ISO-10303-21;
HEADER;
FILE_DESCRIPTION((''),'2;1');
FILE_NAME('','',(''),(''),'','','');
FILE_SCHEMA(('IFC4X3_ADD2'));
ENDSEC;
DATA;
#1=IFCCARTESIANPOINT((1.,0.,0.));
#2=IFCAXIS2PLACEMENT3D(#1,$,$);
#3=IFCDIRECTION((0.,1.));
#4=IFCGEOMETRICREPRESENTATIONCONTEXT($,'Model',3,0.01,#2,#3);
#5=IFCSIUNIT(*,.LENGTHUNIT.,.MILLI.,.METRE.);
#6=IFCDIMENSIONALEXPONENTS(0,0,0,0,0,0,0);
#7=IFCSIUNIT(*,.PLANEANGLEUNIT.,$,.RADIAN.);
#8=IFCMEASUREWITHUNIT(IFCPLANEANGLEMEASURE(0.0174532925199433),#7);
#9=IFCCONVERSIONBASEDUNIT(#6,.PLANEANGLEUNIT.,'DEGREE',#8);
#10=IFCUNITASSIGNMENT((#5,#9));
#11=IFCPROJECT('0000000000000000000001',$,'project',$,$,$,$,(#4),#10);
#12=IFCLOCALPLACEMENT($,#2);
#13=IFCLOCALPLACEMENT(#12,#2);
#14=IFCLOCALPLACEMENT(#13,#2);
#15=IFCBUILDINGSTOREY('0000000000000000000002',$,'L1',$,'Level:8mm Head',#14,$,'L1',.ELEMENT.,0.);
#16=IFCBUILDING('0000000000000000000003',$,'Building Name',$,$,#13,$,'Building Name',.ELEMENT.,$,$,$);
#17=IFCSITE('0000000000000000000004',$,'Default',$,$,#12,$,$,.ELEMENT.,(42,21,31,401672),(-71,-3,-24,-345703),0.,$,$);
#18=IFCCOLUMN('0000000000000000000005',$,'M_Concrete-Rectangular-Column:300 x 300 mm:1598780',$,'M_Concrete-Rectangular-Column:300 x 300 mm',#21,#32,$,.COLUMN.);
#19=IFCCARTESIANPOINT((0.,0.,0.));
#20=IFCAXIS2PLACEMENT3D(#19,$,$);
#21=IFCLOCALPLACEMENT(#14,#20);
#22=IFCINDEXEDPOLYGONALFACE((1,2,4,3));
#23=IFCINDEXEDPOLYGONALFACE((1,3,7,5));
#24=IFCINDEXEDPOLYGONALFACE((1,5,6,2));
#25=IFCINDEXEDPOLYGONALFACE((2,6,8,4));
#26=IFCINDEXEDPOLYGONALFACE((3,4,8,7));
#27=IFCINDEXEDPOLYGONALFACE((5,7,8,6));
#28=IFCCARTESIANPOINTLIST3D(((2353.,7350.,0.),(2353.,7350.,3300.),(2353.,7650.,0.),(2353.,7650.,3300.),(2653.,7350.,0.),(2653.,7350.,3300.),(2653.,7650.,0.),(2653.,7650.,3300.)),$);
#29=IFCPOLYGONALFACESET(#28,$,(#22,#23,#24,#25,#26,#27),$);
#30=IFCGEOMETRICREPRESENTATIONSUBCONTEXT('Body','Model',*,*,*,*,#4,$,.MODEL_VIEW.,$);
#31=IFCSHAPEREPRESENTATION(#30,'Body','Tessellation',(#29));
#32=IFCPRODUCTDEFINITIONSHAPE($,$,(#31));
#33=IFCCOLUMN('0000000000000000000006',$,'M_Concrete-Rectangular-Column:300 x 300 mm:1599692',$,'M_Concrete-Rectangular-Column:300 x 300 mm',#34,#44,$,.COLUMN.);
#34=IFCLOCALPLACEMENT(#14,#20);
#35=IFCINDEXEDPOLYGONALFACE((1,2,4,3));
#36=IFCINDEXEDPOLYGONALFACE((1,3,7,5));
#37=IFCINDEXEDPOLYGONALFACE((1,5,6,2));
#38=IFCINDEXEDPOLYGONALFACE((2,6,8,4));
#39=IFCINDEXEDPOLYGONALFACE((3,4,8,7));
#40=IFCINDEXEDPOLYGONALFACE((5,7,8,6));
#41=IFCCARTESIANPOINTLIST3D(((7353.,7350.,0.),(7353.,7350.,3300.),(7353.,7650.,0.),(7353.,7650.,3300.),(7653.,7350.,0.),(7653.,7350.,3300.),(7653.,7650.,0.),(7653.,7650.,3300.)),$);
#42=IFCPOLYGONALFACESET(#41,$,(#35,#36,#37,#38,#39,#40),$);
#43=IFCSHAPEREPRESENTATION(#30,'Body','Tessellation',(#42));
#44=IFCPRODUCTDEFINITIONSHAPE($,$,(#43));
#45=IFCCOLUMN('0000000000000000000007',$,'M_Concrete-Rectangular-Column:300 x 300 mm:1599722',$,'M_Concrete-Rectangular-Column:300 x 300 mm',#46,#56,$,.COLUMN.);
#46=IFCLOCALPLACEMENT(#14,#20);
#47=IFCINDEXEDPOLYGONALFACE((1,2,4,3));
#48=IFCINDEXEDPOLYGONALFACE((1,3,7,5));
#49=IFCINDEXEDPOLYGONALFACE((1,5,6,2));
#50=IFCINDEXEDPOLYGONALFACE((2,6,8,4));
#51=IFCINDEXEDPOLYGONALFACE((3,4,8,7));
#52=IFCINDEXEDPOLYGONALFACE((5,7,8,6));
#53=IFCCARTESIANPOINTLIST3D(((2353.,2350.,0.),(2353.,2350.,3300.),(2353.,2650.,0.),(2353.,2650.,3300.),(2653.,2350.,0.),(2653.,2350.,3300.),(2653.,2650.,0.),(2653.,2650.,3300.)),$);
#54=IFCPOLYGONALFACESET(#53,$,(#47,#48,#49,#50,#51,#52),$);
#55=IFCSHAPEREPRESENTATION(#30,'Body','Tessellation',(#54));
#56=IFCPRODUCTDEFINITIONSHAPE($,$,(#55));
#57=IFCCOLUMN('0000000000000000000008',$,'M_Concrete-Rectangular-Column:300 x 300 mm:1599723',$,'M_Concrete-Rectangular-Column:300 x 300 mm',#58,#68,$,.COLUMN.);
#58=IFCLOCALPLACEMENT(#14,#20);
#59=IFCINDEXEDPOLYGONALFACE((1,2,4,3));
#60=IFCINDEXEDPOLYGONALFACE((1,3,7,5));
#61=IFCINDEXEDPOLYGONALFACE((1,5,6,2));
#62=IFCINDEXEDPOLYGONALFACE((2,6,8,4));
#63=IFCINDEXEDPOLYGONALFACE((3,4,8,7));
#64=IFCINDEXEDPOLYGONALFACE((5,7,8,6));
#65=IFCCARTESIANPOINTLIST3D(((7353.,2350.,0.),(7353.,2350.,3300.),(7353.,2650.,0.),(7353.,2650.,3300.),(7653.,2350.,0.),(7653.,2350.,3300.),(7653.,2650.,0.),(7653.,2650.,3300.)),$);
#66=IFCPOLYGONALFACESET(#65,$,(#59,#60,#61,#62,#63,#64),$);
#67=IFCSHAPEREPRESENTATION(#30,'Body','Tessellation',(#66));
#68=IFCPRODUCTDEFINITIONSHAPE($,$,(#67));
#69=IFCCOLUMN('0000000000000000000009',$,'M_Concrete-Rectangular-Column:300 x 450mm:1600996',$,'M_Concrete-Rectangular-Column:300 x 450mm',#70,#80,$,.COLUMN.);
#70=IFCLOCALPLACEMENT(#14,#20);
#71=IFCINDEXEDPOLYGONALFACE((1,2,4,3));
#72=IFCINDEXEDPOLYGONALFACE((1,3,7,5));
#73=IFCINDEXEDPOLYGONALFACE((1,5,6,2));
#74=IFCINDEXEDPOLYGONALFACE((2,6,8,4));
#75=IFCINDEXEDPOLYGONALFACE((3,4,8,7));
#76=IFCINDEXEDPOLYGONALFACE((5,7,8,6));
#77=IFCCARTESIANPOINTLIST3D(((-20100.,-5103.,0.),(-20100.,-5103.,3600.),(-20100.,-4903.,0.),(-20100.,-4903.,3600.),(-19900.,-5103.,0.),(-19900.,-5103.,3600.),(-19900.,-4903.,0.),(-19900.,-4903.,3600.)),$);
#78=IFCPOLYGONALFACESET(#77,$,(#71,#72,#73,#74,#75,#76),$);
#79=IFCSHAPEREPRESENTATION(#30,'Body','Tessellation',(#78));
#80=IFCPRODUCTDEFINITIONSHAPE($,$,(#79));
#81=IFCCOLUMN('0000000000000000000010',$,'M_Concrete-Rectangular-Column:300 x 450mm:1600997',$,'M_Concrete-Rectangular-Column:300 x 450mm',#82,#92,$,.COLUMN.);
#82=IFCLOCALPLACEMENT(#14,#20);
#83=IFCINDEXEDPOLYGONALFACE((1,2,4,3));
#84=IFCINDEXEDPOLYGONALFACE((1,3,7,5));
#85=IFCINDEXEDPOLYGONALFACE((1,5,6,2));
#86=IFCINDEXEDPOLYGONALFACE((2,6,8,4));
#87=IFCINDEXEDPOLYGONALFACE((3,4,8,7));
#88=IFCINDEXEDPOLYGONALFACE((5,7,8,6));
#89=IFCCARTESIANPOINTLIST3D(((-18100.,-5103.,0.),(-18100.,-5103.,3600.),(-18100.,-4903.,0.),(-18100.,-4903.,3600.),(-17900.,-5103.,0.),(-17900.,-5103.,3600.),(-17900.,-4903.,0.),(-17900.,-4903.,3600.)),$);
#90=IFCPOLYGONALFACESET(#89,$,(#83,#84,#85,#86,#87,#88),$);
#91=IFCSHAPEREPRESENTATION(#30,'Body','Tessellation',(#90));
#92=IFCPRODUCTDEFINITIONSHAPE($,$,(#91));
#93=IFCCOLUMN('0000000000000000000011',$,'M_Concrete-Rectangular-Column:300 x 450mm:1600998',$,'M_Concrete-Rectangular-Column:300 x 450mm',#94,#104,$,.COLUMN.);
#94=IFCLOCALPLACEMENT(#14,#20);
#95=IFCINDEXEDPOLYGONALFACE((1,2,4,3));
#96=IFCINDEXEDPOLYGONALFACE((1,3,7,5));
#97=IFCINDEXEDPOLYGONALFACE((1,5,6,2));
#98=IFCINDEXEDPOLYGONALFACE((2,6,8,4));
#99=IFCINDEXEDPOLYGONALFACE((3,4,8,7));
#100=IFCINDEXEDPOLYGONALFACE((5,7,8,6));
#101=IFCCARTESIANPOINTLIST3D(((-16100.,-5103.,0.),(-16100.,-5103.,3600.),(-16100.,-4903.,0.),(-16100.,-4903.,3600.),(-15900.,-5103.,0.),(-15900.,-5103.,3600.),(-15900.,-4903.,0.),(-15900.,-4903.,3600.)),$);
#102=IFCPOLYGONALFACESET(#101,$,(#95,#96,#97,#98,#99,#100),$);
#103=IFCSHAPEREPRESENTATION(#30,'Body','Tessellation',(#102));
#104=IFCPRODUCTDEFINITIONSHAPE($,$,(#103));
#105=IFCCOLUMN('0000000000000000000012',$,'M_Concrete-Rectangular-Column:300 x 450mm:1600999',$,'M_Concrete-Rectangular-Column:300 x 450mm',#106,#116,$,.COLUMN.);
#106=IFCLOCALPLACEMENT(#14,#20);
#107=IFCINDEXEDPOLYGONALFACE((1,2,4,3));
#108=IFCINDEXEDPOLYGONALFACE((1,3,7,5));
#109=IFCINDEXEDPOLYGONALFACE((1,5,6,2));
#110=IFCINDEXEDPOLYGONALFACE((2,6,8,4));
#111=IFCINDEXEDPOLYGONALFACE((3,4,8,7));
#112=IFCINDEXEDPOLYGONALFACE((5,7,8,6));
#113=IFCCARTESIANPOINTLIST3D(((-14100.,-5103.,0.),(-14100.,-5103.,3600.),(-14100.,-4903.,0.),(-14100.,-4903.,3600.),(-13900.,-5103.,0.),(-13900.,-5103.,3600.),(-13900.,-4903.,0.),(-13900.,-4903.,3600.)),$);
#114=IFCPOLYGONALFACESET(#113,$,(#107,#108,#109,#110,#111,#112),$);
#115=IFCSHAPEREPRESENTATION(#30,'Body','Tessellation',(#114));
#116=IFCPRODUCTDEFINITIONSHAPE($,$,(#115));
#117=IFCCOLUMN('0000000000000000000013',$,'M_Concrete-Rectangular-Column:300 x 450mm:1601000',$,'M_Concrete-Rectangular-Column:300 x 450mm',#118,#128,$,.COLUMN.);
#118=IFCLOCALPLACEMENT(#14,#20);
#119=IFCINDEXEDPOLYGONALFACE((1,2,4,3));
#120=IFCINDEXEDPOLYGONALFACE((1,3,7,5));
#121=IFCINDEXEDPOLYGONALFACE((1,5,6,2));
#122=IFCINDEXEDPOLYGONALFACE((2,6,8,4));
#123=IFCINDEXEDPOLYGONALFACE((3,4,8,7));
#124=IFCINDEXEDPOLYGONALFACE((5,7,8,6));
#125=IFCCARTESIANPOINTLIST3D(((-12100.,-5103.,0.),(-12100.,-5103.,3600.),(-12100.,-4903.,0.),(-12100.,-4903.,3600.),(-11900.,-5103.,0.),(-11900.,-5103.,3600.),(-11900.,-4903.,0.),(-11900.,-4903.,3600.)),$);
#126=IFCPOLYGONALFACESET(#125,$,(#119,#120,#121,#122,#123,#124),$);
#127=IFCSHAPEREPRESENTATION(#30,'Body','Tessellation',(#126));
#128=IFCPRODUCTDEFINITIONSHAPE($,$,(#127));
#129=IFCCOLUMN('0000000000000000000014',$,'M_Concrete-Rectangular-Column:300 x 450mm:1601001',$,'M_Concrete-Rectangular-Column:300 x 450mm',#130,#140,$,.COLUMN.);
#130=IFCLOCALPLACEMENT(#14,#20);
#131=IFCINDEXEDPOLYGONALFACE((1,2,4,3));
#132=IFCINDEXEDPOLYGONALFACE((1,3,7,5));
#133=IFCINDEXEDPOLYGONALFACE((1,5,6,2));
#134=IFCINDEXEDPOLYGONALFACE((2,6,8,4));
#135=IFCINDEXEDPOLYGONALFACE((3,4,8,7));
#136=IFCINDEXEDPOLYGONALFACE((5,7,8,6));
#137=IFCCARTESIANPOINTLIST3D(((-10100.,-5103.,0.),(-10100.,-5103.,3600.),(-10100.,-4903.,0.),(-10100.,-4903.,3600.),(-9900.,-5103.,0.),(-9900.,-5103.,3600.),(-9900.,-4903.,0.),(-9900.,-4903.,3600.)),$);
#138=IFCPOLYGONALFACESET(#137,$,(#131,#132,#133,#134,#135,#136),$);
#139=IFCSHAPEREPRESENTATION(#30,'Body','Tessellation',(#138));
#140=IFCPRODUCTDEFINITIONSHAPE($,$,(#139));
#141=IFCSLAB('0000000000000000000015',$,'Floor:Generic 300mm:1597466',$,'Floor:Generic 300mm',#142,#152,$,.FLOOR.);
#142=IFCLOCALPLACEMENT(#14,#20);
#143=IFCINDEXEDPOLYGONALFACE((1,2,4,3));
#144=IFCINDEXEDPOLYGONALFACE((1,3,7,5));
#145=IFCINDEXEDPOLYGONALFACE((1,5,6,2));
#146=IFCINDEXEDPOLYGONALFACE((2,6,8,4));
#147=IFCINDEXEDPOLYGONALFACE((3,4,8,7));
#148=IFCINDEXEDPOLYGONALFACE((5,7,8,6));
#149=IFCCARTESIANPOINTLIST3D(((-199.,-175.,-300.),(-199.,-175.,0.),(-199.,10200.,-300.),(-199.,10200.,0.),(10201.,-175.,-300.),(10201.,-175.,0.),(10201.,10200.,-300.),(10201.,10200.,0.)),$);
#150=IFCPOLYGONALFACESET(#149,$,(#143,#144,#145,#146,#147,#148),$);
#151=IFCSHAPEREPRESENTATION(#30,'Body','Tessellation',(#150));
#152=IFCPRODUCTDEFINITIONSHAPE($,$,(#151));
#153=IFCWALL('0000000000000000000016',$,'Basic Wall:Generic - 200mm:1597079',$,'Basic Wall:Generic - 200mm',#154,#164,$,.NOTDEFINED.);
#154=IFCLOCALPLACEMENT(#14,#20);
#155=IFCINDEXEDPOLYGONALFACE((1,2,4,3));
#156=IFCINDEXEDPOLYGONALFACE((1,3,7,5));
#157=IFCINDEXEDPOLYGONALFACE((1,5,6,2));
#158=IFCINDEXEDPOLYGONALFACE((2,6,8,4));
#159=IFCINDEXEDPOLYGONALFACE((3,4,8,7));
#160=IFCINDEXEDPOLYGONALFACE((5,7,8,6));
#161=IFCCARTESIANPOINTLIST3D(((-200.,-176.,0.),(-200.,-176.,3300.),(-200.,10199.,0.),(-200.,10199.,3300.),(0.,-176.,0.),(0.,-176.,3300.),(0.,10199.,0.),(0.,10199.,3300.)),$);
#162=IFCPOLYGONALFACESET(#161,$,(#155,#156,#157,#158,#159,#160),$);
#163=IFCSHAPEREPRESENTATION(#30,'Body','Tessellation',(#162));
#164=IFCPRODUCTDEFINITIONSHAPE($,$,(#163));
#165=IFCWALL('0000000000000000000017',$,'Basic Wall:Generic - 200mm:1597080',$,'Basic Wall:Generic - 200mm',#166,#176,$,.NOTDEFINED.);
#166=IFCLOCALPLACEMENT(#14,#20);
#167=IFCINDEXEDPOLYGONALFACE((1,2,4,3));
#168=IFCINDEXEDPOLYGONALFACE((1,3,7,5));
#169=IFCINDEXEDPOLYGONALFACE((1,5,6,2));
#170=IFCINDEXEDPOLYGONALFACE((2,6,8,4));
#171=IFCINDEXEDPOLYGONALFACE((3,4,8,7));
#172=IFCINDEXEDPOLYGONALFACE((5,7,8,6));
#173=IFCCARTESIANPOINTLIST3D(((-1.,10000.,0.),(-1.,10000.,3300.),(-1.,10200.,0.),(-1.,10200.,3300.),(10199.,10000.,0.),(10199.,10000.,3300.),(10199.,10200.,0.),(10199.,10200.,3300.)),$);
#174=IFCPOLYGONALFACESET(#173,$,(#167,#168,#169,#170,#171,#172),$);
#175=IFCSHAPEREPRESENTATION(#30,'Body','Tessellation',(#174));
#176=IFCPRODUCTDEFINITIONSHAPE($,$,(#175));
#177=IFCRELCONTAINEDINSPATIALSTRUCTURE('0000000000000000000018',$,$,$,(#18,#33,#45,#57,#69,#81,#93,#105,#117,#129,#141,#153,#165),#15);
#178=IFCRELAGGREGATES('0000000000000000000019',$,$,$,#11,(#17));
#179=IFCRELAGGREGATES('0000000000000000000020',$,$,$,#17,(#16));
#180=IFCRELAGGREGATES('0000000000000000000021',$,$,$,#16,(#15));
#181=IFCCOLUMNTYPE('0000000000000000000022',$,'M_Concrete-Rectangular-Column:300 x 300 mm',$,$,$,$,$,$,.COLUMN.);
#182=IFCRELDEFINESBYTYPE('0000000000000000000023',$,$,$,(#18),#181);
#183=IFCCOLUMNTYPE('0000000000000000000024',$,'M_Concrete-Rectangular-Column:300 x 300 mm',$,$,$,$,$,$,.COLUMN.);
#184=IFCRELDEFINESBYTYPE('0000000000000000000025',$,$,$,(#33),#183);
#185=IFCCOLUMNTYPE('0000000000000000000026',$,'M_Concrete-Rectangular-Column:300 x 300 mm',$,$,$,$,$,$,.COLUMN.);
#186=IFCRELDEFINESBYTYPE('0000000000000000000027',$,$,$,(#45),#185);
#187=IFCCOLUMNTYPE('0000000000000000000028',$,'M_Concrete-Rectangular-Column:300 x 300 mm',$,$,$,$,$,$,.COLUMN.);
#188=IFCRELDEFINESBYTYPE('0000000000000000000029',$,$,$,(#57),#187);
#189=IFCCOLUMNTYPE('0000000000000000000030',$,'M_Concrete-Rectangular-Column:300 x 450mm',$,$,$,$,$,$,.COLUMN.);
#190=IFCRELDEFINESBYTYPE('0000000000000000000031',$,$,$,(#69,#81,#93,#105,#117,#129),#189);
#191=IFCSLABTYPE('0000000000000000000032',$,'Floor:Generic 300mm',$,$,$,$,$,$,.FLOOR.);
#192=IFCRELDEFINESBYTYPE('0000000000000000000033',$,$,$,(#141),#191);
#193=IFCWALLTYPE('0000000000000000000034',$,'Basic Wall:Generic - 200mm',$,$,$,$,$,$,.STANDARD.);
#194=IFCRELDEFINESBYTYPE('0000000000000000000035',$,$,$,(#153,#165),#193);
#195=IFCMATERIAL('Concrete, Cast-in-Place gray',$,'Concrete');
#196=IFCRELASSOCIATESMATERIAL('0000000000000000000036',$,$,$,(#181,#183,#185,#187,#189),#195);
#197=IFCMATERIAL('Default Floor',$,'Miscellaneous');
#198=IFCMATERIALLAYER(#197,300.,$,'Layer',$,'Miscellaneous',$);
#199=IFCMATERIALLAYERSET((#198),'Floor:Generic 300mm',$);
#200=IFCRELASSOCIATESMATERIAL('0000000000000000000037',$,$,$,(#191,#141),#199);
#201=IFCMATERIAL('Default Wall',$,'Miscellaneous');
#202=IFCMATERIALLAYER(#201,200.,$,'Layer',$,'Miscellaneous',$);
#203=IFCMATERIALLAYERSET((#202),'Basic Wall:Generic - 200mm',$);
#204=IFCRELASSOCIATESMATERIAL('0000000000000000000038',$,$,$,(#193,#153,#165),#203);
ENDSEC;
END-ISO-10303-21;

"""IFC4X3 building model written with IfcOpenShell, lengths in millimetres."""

from ifc_helpers import new_model, entity, si_unit, converted_unit, direction, frame, frame_2d, origin_2d_with_axis, place, context, subcontext, project, spatial, rectangle, extrude, source, transform, mapped, material, layer, layer_set, layer_usage, material_profile, profile_set, type_object, type_shapes, element, save


model = new_model("IFC4X3")

# Units and contexts
model_context = context("Model", 3, precision=0.01, world=frame((1.0, 0.0, 0.0)), true_north=direction((0.0, 1.0)))
body_context = subcontext(model_context, "Body", "Model", "MODEL_VIEW")
ifc_project = project(units=[si_unit("LENGTHUNIT", "METRE", prefix="MILLI"), converted_unit("PLANEANGLEUNIT", "DEGREE", entity("IfcPlaneAngleMeasure", 0.0174532925199433), si_unit("PLANEANGLEUNIT", "RADIAN"), dimensions=[0, 0, 0, 0, 0, 0, 0])], contexts=[model_context])

# Site, building, storey
site_placement = place(None, frame((1.0, 0.0, 0.0)))
site = spatial("IfcSite", under=ifc_project, at=site_placement, Name="Default", CompositionType="ELEMENT", RefLatitude=(42, 21, 31, 401672), RefLongitude=(-71, -3, -24, -345703), RefElevation=0.0)
building_placement = place(site_placement, frame((1.0, 0.0, 0.0)))
building = spatial("IfcBuilding", under=site, at=building_placement, Name="Building Name", LongName="Building Name", CompositionType="ELEMENT")
storey_placement = place(building_placement, frame((1.0, 0.0, 0.0)))
storey = spatial("IfcBuildingStorey", under=building, at=storey_placement, Name="L1", ObjectType="Level:8mm Head", LongName="L1", CompositionType="ELEMENT", Elevation=0.0)

# Columns
ifc_material_1 = material(Name="Concrete, Cast-in-Place gray", Category="Concrete")
ifc_material_profile_1 = material_profile(ifc_material_1, rectangle(XDim=300.0, YDim=300.0, at=origin_2d_with_axis()), Name="300 x 300 mm")
ifc_profile_set_1 = profile_set([ifc_material_profile_1], Name="300 x 300 mm")
column_type_1 = type_object("IfcColumnType", Name="M_Concrete-Rectangular-Column:300 x 300 mm", PredefinedType="COLUMN", material=ifc_profile_set_1)
shared_shape_1 = source(frame((1.0, 0.0, 0.0)), body_context, "Body", "SweptSolid", [
    extrude(rectangle(XDim=300.0, YDim=300.0, at=origin_2d_with_axis()), frame((2500.0, 7500.0, 0.0)), (0.0, 0.0, 1.0), 3300.0),
])
type_shapes(column_type_1, [shared_shape_1])
column_1_placement = place(storey_placement, frame((1.0, 0.0, 0.0)))
element("IfcColumn", 1, at=column_1_placement, inside=storey, type_object=column_type_1, Name="M_Concrete-Rectangular-Column:300 x 300 mm:1598780", ObjectType="M_Concrete-Rectangular-Column:300 x 300 mm", PredefinedType="COLUMN", context=body_context, shape_type="MappedRepresentation", body=[
    mapped(shared_shape_1, transform((1.0, 0.0, 0.0), scale=1.0)),
])
column_type_2 = type_object("IfcColumnType", Name="M_Concrete-Rectangular-Column:300 x 300 mm", PredefinedType="COLUMN", material=ifc_profile_set_1)
shared_shape_2 = source(frame((1.0, 0.0, 0.0)), body_context, "Body", "SweptSolid", [
    extrude(rectangle(XDim=300.0, YDim=300.0, at=origin_2d_with_axis()), frame((7500.0, 7500.0, 0.0)), (0.0, 0.0, 1.0), 3300.0),
])
type_shapes(column_type_2, [shared_shape_2])
column_2_placement = place(storey_placement, frame((1.0, 0.0, 0.0)))
element("IfcColumn", 2, at=column_2_placement, inside=storey, type_object=column_type_2, Name="M_Concrete-Rectangular-Column:300 x 300 mm:1599692", ObjectType="M_Concrete-Rectangular-Column:300 x 300 mm", PredefinedType="COLUMN", context=body_context, shape_type="MappedRepresentation", body=[
    mapped(shared_shape_2, transform((1.0, 0.0, 0.0), scale=1.0)),
])
column_type_3 = type_object("IfcColumnType", Name="M_Concrete-Rectangular-Column:300 x 300 mm", PredefinedType="COLUMN", material=ifc_profile_set_1)
shared_shape_3 = source(frame((1.0, 0.0, 0.0)), body_context, "Body", "SweptSolid", [
    extrude(rectangle(XDim=300.0, YDim=300.0, at=origin_2d_with_axis()), frame((2500.0, 2500.0, 0.0)), (0.0, 0.0, 1.0), 3300.0),
])
type_shapes(column_type_3, [shared_shape_3])
column_3_placement = place(storey_placement, frame((1.0, 0.0, 0.0)))
element("IfcColumn", 3, at=column_3_placement, inside=storey, type_object=column_type_3, Name="M_Concrete-Rectangular-Column:300 x 300 mm:1599722", ObjectType="M_Concrete-Rectangular-Column:300 x 300 mm", PredefinedType="COLUMN", context=body_context, shape_type="MappedRepresentation", body=[
    mapped(shared_shape_3, transform((1.0, 0.0, 0.0), scale=1.0)),
])
column_type_4 = type_object("IfcColumnType", Name="M_Concrete-Rectangular-Column:300 x 300 mm", PredefinedType="COLUMN", material=ifc_profile_set_1)
shared_shape_4 = source(frame((1.0, 0.0, 0.0)), body_context, "Body", "SweptSolid", [
    extrude(rectangle(XDim=300.0, YDim=300.0, at=origin_2d_with_axis()), frame((7500.0, 2500.0, 0.0)), (0.0, 0.0, 1.0), 3300.0),
])
type_shapes(column_type_4, [shared_shape_4])
column_4_placement = place(storey_placement, frame((1.0, 0.0, 0.0)))
element("IfcColumn", 4, at=column_4_placement, inside=storey, type_object=column_type_4, Name="M_Concrete-Rectangular-Column:300 x 300 mm:1599723", ObjectType="M_Concrete-Rectangular-Column:300 x 300 mm", PredefinedType="COLUMN", context=body_context, shape_type="MappedRepresentation", body=[
    mapped(shared_shape_4, transform((1.0, 0.0, 0.0), scale=1.0)),
])
ifc_material_profile_2 = material_profile(ifc_material_1, rectangle(XDim=200.0, YDim=200.0, at=origin_2d_with_axis()), Name="300 x 450mm")
ifc_profile_set_2 = profile_set([ifc_material_profile_2], Name="300 x 450mm")
column_type_5 = type_object("IfcColumnType", Name="M_Concrete-Rectangular-Column:300 x 450mm", PredefinedType="COLUMN", material=ifc_profile_set_2)
shared_shape_5 = source(frame((1.0, 0.0, 0.0)), body_context, "Body", "SweptSolid", [
    extrude(rectangle(XDim=200.0, YDim=200.0, at=origin_2d_with_axis()), frame((1.0, 0.0, 0.0), z_axis=(0.0, 0.0, 1.0), x_axis=(-1.0, 0.0, 0.0)), (0.0, 0.0, 1.0), 3600.0),
])
type_shapes(column_type_5, [shared_shape_5])
for number, where, z_axis, x_axis, name in (
    (5, (-20000.0, -5000.0, 0.0), (0.0, 0.0, 1.0), (0.0, -1.0, 0.0), "M_Concrete-Rectangular-Column:300 x 450mm:1600996"),
    (6, (-18000.0, -5000.0, 0.0), (0.0, 0.0, 1.0), (0.0, -1.0, 0.0), "M_Concrete-Rectangular-Column:300 x 450mm:1600997"),
    (7, (-16000.0, -5000.0, 0.0), (0.0, 0.0, 1.0), (0.0, -1.0, 0.0), "M_Concrete-Rectangular-Column:300 x 450mm:1600998"),
    (8, (-14000.0, -5000.0, 0.0), (0.0, 0.0, 1.0), (0.0, -1.0, 0.0), "M_Concrete-Rectangular-Column:300 x 450mm:1600999"),
    (9, (-12000.0, -5000.0, 0.0), (0.0, 0.0, 1.0), (0.0, -1.0, 0.0), "M_Concrete-Rectangular-Column:300 x 450mm:1601000"),
    (10, (-10000.0, -5000.0, 0.0), (0.0, 0.0, 1.0), (0.0, -1.0, 0.0), "M_Concrete-Rectangular-Column:300 x 450mm:1601001"),
):
    element("IfcColumn", number, at=place(storey_placement, frame(where, z_axis=z_axis, x_axis=x_axis)), inside=storey, type_object=column_type_5, Name=name, ObjectType="M_Concrete-Rectangular-Column:300 x 450mm", PredefinedType="COLUMN", context=body_context, shape_type="MappedRepresentation", body=[
        mapped(shared_shape_5, transform((1.0, 0.0, 0.0), scale=1.0)),
    ])

# Slab
ifc_material_2 = material(Name="Default Floor", Category="Miscellaneous")
ifc_layer_1 = layer(ifc_material_2, 300.0, Name="Layer", Category="Miscellaneous")
ifc_layer_set_1 = layer_set([ifc_layer_1], Name="Floor:Generic 300mm")
ifc_layer_usage = layer_usage(ifc_layer_set_1, "AXIS3", "POSITIVE", 0.0)
slab_type = type_object("IfcSlabType", Name="Floor:Generic 300mm", PredefinedType="FLOOR", material=ifc_layer_set_1)
slab_placement = place(storey_placement, frame((1.0, 0.0, 0.0)))
element("IfcSlab", 11, at=slab_placement, inside=storey, type_object=slab_type, material=ifc_layer_usage, Name="Floor:Generic 300mm:1597466", ObjectType="Floor:Generic 300mm", PredefinedType="FLOOR", context=body_context, shape_type="SweptSolid", body=[
    extrude(rectangle(XDim=10375.0, YDim=10400.0, at=origin_2d_with_axis()), frame((5000.0, 5012.5, 0.0), z_axis=(0.0, 0.0, -1.0), x_axis=(0.0, 1.0, 0.0)), (0.0, 0.0, 1.0), 300.0),
])

# Walls
ifc_material_3 = material(Name="Default Wall", Category="Miscellaneous")
ifc_layer_2 = layer(ifc_material_3, 200.0, Name="Layer", Category="Miscellaneous")
ifc_layer_set_2 = layer_set([ifc_layer_2], Name="Basic Wall:Generic - 200mm")
wall_type_1 = type_object("IfcWallType", Name="Basic Wall:Generic - 200mm", PredefinedType="STANDARD", material=ifc_layer_set_2)
wall_1_placement = place(storey_placement, frame((-100.0, 10200.0, 0.0), z_axis=(0.0, 0.0, 1.0), x_axis=(0.0, -1.0, 0.0)))
element("IfcWall", 12, at=wall_1_placement, inside=storey, type_object=wall_type_1, material=ifc_layer_set_2, Name="Basic Wall:Generic - 200mm:1597079", ObjectType="Basic Wall:Generic - 200mm", PredefinedType="NOTDEFINED", context=body_context, shape_type="SweptSolid", body=[
    extrude(rectangle(XDim=10375.0, YDim=200.0, at=frame_2d((5187.5, 0.0), x_axis=(-1.0, 0.0))), frame((1.0, 0.0, 0.0)), (0.0, 0.0, 1.0), 3300.0),
])
wall_2_placement = place(storey_placement, frame((10200.0, 10100.0, 0.0), z_axis=(0.0, 0.0, 1.0), x_axis=(-1.0, 0.0, 0.0)))
element("IfcWall", 13, at=wall_2_placement, inside=storey, type_object=wall_type_1, material=ifc_layer_set_2, Name="Basic Wall:Generic - 200mm:1597080", ObjectType="Basic Wall:Generic - 200mm", PredefinedType="NOTDEFINED", context=body_context, shape_type="SweptSolid", body=[
    extrude(rectangle(XDim=10200.0, YDim=200.0, at=frame_2d((5100.0, 0.0), x_axis=(-1.0, 0.0))), frame((1.0, 0.0, 0.0)), (0.0, 0.0, 1.0), 3300.0),
])

save(model, "model.ifc")
